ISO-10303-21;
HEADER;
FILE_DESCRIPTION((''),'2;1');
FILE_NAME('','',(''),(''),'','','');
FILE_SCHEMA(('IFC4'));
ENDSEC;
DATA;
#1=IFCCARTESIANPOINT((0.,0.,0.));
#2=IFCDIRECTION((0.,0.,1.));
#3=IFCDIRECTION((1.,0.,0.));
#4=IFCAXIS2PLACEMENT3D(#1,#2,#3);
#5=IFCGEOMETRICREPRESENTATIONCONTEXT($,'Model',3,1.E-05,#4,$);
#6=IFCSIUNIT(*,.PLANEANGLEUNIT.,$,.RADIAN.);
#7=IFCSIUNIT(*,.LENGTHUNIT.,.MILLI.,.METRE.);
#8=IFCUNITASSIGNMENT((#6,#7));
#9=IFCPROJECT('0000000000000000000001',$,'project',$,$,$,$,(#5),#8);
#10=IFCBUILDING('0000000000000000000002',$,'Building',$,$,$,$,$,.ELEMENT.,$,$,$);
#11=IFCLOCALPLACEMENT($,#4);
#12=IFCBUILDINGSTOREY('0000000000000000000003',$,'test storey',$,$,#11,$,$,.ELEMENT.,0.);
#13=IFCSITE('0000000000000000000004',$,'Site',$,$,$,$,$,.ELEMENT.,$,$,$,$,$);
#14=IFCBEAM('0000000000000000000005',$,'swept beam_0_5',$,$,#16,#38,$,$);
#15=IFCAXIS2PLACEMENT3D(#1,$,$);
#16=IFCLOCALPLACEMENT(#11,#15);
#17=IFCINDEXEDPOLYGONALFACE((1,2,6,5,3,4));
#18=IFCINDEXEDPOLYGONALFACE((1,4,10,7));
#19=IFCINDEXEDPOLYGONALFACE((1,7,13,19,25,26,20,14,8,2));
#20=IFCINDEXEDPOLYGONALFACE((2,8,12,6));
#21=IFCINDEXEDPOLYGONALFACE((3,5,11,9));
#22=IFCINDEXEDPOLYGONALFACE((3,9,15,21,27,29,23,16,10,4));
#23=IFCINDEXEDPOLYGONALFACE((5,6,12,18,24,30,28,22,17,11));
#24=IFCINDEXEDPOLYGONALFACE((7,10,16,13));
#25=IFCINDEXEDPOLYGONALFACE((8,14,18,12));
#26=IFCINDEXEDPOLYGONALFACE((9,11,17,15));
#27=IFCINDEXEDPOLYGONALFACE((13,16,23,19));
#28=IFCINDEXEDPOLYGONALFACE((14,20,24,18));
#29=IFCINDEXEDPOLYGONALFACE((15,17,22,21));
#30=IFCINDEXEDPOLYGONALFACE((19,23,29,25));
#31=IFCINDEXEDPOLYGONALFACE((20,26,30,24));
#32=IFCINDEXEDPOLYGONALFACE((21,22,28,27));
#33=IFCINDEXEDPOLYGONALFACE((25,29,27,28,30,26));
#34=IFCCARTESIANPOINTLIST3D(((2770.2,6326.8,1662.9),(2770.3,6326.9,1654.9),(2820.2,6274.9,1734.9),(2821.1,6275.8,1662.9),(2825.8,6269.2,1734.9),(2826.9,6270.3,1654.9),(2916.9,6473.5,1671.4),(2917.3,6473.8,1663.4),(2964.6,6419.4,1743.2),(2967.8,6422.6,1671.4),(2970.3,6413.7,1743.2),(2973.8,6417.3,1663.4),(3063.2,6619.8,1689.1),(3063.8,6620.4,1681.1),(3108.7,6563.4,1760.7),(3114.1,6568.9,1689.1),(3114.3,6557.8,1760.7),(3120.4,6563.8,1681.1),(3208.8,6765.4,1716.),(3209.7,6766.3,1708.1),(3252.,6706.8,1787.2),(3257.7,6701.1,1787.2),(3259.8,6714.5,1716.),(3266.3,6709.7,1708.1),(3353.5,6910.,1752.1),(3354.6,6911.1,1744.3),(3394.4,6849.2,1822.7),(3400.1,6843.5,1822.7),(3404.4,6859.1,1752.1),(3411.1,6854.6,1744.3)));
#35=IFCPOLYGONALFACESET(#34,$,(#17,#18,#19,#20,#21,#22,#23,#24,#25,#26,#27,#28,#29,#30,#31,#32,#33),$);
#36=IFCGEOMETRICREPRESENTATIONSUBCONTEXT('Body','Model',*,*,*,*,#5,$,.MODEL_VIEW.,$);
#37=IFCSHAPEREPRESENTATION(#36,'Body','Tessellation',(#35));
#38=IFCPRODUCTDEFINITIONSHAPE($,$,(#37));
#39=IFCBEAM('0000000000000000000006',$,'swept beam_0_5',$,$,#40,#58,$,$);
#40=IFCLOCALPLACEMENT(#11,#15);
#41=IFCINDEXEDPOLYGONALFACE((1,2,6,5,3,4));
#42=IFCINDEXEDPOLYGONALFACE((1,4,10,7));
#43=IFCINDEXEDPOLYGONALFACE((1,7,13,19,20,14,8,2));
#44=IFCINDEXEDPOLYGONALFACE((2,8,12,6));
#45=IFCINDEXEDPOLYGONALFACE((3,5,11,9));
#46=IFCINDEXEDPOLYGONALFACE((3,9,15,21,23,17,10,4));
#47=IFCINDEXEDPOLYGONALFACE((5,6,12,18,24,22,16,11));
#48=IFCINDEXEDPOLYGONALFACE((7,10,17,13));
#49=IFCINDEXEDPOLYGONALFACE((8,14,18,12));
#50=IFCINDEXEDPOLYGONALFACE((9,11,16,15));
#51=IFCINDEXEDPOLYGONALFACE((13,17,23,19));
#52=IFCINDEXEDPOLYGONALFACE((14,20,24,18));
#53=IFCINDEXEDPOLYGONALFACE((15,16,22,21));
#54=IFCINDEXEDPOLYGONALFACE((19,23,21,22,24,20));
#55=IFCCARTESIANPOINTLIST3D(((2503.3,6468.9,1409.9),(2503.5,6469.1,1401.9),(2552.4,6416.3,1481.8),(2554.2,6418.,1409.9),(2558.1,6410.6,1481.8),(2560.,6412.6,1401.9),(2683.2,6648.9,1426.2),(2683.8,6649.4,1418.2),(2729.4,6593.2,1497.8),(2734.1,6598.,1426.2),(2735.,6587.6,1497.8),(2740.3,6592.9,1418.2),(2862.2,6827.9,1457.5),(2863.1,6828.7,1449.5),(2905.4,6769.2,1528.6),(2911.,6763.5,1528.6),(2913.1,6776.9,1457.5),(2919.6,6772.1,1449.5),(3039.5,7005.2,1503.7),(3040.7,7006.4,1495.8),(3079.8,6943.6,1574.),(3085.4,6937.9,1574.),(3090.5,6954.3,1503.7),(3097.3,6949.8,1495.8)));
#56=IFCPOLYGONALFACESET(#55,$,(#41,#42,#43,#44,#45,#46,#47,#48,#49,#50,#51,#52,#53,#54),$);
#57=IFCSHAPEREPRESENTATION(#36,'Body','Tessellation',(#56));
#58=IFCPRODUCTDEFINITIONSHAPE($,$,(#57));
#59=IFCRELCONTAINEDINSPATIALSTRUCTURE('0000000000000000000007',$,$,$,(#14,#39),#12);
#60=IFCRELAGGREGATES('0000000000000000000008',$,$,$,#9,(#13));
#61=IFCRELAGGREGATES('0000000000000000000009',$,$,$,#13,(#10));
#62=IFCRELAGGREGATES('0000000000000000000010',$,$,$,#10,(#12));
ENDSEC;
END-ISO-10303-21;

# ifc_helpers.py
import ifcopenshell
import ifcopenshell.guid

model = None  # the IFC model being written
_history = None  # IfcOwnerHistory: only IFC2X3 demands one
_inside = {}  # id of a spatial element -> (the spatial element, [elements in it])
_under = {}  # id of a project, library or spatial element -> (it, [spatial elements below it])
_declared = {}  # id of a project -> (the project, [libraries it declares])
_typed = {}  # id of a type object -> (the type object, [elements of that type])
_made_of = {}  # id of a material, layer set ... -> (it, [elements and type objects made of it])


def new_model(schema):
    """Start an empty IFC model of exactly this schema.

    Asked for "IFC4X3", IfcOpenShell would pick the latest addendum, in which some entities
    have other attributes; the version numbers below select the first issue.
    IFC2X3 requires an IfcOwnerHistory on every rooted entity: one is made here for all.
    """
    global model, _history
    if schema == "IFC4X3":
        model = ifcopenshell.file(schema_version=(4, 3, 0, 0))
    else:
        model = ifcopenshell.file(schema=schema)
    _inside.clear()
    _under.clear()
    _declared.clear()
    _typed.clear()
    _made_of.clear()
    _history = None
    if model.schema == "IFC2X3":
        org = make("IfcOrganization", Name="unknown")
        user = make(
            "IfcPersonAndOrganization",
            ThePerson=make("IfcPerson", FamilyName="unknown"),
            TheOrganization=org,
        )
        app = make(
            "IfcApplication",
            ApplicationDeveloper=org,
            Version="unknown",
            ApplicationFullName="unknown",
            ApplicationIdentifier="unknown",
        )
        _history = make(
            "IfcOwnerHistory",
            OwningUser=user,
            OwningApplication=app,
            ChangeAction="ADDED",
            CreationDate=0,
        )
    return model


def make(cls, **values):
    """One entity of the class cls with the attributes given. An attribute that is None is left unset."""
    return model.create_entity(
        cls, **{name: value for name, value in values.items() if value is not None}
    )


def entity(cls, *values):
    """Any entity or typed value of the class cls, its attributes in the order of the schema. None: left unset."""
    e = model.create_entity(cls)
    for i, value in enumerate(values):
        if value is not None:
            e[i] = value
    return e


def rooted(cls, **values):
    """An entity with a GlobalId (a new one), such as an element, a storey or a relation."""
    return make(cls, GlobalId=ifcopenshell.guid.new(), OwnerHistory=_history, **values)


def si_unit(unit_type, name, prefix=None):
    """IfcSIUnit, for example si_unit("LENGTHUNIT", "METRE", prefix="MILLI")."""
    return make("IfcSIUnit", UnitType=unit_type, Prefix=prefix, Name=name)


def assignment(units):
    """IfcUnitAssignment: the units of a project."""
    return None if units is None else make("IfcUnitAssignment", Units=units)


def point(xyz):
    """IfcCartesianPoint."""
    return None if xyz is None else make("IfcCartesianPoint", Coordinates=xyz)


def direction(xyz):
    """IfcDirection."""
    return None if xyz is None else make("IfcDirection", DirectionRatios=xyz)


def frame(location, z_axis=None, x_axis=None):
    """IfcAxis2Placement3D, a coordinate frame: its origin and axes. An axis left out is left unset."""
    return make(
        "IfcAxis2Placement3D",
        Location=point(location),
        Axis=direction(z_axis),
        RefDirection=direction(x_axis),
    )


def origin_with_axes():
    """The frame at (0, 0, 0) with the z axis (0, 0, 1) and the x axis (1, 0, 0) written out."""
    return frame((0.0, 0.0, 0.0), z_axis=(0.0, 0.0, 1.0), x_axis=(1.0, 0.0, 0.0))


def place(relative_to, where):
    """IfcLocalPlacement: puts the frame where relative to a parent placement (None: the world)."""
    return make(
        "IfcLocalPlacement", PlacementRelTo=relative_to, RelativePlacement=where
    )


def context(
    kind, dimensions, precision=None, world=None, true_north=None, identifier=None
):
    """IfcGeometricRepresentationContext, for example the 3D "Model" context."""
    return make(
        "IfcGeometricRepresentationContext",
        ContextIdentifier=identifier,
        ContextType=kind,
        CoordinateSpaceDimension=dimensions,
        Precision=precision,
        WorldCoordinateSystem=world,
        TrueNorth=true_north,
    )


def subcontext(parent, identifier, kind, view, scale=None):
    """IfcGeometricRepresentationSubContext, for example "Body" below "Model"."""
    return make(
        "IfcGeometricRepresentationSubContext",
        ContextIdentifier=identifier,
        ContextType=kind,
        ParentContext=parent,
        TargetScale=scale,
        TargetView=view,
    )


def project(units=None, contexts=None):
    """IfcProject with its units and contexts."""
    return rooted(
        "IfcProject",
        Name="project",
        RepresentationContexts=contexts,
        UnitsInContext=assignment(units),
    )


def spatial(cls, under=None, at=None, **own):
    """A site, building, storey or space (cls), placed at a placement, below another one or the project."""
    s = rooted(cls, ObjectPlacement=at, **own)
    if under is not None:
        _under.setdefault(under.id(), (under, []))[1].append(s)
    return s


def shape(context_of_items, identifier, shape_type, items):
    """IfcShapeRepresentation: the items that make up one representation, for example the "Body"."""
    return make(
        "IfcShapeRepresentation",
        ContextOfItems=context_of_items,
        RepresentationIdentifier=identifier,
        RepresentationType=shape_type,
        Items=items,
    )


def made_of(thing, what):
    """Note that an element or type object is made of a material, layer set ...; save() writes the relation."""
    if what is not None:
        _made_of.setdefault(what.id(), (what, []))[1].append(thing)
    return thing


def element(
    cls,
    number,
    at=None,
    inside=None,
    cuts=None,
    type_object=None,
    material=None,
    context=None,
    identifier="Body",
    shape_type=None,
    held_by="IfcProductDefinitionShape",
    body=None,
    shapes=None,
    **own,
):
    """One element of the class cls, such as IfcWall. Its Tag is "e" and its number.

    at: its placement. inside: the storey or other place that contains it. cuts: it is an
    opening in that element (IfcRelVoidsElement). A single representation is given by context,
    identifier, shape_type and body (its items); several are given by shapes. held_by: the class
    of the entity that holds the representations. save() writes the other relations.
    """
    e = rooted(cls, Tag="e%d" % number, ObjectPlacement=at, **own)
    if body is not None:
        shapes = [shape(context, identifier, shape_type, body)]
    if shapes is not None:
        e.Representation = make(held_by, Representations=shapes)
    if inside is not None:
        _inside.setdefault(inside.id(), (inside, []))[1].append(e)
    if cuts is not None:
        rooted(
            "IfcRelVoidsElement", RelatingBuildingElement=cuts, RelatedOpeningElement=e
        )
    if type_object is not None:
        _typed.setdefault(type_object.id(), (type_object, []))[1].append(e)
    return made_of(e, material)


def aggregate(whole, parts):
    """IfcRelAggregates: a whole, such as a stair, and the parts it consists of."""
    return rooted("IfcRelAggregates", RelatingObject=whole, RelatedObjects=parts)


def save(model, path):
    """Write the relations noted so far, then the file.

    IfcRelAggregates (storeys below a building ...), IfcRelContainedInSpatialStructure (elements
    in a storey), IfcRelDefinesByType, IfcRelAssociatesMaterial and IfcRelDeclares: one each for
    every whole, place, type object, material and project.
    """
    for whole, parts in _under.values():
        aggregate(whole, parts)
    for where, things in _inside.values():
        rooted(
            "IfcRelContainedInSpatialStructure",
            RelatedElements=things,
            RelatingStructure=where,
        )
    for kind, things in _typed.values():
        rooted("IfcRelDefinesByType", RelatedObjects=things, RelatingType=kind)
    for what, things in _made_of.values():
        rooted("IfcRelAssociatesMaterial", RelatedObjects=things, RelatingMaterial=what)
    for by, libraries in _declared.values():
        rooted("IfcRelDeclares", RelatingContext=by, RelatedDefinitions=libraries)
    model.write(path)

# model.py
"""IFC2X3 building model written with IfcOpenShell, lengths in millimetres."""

from ifc_helpers import new_model, entity, si_unit, origin_with_axes, place, context, subcontext, project, spatial, element, save


model = new_model("IFC2X3")

# Units and contexts
model_context = context("Model", 3, precision=1e-05, world=origin_with_axes())
body_context = subcontext(model_context, "Body", "Model", "MODEL_VIEW")
ifc_project = project(units=[si_unit("PLANEANGLEUNIT", "RADIAN"), si_unit("LENGTHUNIT", "METRE", prefix="MILLI")], contexts=[model_context])

# Site, building, storey
site = spatial("IfcSite", under=ifc_project, Name="Site", CompositionType="ELEMENT")
building = spatial("IfcBuilding", under=site, Name="Building", CompositionType="ELEMENT")
storey_placement = place(None, origin_with_axes())
storey = spatial("IfcBuildingStorey", under=building, at=storey_placement, Name="test storey", CompositionType="ELEMENT", Elevation=0.0)

# Beams
beam_1_placement = place(storey_placement, origin_with_axes())
element("IfcBeam", 1, at=beam_1_placement, inside=storey, Name="swept beam_0_5", context=body_context, shape_type="SweptSolid", body=[
    entity("IfcRevolvedAreaSolid", entity("IfcArbitraryClosedProfileDef", "AREA", None, entity("IfcPolyline", [entity("IfcCartesianPoint", [-80.0, 40.0]), entity("IfcCartesianPoint", [-80.0, 32.0]), entity("IfcCartesianPoint", [-8.0, 32.0]), entity("IfcCartesianPoint", [-8.0, -40.0]), entity("IfcCartesianPoint", [0.0, -40.0]), entity("IfcCartesianPoint", [0.0, 40.0]), entity("IfcCartesianPoint", [-80.0, 40.0])])), entity("IfcAxis2Placement3D", entity("IfcCartesianPoint", [2798.6, 6298.6, 1654.9]), entity("IfcDirection", [-0.707, -0.707, -0.0184]), entity("IfcDirection", [0.013, 0.013, -0.9998])), entity("IfcAxis1Placement", entity("IfcCartesianPoint", [-4656.3, 0.0, 0.0]), entity("IfcDirection", [0.0, 1.0, 0.0])), 0.178731),
])
beam_2_placement = place(storey_placement, origin_with_axes())
element("IfcBeam", 2, at=beam_2_placement, inside=storey, Name="swept beam_0_5", context=body_context, shape_type="SweptSolid", body=[
    entity("IfcRevolvedAreaSolid", entity("IfcArbitraryClosedProfileDef", "AREA", None, entity("IfcPolyline", [entity("IfcCartesianPoint", [-80.0, 40.0]), entity("IfcCartesianPoint", [-80.0, 32.0]), entity("IfcCartesianPoint", [-8.0, 32.0]), entity("IfcCartesianPoint", [-8.0, -40.0]), entity("IfcCartesianPoint", [0.0, -40.0]), entity("IfcCartesianPoint", [0.0, 40.0]), entity("IfcCartesianPoint", [-80.0, 40.0])])), entity("IfcAxis2Placement3D", entity("IfcCartesianPoint", [2531.7, 6440.8, 1401.9]), entity("IfcDirection", [-0.7067, -0.7067, -0.0343]), entity("IfcDirection", [0.0243, 0.0243, -0.9994])), entity("IfcAxis1Placement", entity("IfcCartesianPoint", [-4320.2, 0.0, 0.0]), entity("IfcDirection", [0.0, 1.0, 0.0])), 0.177445),
])

save(model, "model.ifc")
